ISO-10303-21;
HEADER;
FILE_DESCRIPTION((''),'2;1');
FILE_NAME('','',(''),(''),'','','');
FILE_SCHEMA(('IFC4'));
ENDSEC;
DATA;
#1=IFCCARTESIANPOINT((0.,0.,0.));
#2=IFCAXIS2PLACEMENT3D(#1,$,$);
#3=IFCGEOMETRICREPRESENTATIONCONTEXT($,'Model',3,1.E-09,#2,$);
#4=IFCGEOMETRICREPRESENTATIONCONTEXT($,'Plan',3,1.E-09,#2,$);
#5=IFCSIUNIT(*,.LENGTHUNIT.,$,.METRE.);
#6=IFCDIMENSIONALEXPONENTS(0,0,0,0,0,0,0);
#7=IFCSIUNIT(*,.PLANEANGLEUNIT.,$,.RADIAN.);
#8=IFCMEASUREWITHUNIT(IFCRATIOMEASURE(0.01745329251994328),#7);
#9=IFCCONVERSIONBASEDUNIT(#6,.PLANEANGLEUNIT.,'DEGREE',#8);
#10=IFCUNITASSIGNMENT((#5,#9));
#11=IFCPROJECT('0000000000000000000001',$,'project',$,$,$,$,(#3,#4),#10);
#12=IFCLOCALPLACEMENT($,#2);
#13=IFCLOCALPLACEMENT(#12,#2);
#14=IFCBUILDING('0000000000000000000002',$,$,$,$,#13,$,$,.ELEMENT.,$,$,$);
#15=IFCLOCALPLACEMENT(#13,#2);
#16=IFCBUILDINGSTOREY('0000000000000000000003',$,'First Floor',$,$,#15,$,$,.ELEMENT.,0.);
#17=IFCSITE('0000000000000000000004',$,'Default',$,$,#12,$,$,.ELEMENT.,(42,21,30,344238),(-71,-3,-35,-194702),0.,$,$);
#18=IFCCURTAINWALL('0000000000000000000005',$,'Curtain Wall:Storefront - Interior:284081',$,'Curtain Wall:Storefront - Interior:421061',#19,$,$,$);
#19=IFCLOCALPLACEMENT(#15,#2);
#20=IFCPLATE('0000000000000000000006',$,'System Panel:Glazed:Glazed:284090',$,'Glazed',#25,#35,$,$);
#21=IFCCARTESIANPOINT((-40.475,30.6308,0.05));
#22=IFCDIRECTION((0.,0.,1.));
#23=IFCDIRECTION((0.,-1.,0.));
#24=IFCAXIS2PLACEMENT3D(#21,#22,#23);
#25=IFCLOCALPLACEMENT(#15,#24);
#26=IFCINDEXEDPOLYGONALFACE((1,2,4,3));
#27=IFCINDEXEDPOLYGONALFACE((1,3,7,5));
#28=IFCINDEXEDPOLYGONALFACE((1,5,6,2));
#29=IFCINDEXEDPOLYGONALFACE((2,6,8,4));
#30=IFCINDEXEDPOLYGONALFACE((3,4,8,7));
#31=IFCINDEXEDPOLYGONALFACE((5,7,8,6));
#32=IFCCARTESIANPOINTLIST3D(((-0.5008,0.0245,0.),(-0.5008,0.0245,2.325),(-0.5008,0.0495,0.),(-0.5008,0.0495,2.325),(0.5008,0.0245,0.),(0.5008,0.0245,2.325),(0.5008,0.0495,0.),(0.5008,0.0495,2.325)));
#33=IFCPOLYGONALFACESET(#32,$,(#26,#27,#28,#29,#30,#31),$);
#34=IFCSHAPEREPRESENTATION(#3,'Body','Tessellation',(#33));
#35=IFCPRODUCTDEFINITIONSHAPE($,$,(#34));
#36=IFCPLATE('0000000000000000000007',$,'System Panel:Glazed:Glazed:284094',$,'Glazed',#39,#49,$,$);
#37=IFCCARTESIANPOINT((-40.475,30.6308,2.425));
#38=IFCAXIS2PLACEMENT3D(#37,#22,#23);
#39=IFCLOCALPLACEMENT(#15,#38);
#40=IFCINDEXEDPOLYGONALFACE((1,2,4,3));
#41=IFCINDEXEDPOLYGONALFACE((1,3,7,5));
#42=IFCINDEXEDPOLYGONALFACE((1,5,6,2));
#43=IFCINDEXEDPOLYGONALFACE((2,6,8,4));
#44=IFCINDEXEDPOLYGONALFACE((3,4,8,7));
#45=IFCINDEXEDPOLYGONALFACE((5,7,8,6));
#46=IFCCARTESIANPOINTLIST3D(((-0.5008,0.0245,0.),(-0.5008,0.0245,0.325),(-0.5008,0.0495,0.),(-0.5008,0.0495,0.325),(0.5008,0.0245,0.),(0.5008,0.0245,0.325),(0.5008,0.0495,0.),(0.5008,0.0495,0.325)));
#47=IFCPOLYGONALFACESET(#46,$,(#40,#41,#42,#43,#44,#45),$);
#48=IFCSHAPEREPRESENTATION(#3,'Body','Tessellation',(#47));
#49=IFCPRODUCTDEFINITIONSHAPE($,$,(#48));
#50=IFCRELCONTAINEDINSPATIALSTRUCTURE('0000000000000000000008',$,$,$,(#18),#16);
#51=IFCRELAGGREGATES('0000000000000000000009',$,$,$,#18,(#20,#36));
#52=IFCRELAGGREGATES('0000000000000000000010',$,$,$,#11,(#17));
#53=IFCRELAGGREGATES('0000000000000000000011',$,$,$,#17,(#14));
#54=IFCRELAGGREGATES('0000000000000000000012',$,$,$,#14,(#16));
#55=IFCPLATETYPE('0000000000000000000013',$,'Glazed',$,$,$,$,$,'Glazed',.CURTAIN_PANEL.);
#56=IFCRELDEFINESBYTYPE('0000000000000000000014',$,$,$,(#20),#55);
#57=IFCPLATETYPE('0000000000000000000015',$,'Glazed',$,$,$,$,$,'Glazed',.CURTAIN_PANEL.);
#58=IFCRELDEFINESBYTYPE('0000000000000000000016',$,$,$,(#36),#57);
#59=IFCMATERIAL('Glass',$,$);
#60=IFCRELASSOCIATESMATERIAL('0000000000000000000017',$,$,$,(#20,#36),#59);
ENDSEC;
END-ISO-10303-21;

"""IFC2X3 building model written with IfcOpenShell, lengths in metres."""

from ifc_helpers import new_model, entity, si_unit, converted_unit, frame, origin, origin_2d_with_axis, place, context, project, spatial, rectangle, extrude, source, transform, mapped, material, type_object, type_shapes, element, aggregate, save


model = new_model("IFC2X3")

# Units and contexts
model_context = context("Model", 3, precision=1e-09, world=origin())
plan_context = context("Plan", 3, precision=1e-09, world=origin())
ifc_project = project(units=[si_unit("LENGTHUNIT", "METRE"), converted_unit("PLANEANGLEUNIT", "DEGREE", entity("IfcRatioMeasure", 0.01745329251994328), si_unit("PLANEANGLEUNIT", "RADIAN"), dimensions=[0, 0, 0, 0, 0, 0, 0])], contexts=[model_context, plan_context])

# Site, building, storey
site_placement = place(None, origin())
site = spatial("IfcSite", under=ifc_project, at=site_placement, Name="Default", CompositionType="ELEMENT", RefLatitude=(42, 21, 30, 344238), RefLongitude=(-71, -3, -35, -194702), RefElevation=0.0)
building_placement = place(site_placement, origin())
building = spatial("IfcBuilding", under=site, at=building_placement, CompositionType="ELEMENT")
storey_placement = place(building_placement, origin())
storey = spatial("IfcBuildingStorey", under=building, at=storey_placement, Name="First Floor", CompositionType="ELEMENT", Elevation=0.0)

# Curtain wall
curtain_wall_1_placement = place(storey_placement, origin())
curtain_wall_1 = element("IfcCurtainWall", 1, at=curtain_wall_1_placement, inside=storey, Name="Curtain Wall:Storefront - Interior:284081", ObjectType="Curtain Wall:Storefront - Interior:421061")

# Plates
ifc_material_1 = material(Name="Glass")
plate_type_1 = type_object("IfcPlateType", Name="Glazed", ElementType="Glazed", PredefinedType="CURTAIN_PANEL")
shared_shape_1 = source(origin(), model_context, "Body", "SweptSolid", [
    extrude(rectangle(XDim=0.025, YDim=1.0017, at=origin_2d_with_axis()), frame((0.0, 0.037, 0.0), z_axis=(0.0, 0.0, 1.0), x_axis=(0.0, 1.0, 0.0)), (0.0, 0.0, 1.0), 2.325),
])
type_shapes(plate_type_1, [shared_shape_1])
plate_1_placement = place(storey_placement, frame((-40.475, 30.6308, 0.05), z_axis=(0.0, 0.0, 1.0), x_axis=(0.0, -1.0, 0.0)))
plate_1 = element("IfcPlate", 2, at=plate_1_placement, type_object=plate_type_1, material=ifc_material_1, Name="System Panel:Glazed:Glazed:284090", ObjectType="Glazed", context=model_context, shape_type="MappedRepresentation", body=[
    mapped(shared_shape_1, transform((0.0, 0.0, 0.0), scale=1.0)),
])
plate_type_2 = type_object("IfcPlateType", Name="Glazed", ElementType="Glazed", PredefinedType="CURTAIN_PANEL")
shared_shape_2 = source(origin(), model_context, "Body", "SweptSolid", [
    extrude(rectangle(XDim=0.025, YDim=1.0017, at=origin_2d_with_axis()), frame((0.0, 0.037, 0.0), z_axis=(0.0, 0.0, 1.0), x_axis=(0.0, 1.0, 0.0)), (0.0, 0.0, 1.0), 0.325),
])
type_shapes(plate_type_2, [shared_shape_2])
plate_2_placement = place(storey_placement, frame((-40.475, 30.6308, 2.425), z_axis=(0.0, 0.0, 1.0), x_axis=(0.0, -1.0, 0.0)))
plate_2 = element("IfcPlate", 3, at=plate_2_placement, type_object=plate_type_2, material=ifc_material_1, Name="System Panel:Glazed:Glazed:284094", ObjectType="Glazed", context=model_context, shape_type="MappedRepresentation", body=[
    mapped(shared_shape_2, transform((0.0, 0.0, 0.0), scale=1.0)),
])
aggregate(curtain_wall_1, [plate_1, plate_2])

save(model, "model.ifc")
